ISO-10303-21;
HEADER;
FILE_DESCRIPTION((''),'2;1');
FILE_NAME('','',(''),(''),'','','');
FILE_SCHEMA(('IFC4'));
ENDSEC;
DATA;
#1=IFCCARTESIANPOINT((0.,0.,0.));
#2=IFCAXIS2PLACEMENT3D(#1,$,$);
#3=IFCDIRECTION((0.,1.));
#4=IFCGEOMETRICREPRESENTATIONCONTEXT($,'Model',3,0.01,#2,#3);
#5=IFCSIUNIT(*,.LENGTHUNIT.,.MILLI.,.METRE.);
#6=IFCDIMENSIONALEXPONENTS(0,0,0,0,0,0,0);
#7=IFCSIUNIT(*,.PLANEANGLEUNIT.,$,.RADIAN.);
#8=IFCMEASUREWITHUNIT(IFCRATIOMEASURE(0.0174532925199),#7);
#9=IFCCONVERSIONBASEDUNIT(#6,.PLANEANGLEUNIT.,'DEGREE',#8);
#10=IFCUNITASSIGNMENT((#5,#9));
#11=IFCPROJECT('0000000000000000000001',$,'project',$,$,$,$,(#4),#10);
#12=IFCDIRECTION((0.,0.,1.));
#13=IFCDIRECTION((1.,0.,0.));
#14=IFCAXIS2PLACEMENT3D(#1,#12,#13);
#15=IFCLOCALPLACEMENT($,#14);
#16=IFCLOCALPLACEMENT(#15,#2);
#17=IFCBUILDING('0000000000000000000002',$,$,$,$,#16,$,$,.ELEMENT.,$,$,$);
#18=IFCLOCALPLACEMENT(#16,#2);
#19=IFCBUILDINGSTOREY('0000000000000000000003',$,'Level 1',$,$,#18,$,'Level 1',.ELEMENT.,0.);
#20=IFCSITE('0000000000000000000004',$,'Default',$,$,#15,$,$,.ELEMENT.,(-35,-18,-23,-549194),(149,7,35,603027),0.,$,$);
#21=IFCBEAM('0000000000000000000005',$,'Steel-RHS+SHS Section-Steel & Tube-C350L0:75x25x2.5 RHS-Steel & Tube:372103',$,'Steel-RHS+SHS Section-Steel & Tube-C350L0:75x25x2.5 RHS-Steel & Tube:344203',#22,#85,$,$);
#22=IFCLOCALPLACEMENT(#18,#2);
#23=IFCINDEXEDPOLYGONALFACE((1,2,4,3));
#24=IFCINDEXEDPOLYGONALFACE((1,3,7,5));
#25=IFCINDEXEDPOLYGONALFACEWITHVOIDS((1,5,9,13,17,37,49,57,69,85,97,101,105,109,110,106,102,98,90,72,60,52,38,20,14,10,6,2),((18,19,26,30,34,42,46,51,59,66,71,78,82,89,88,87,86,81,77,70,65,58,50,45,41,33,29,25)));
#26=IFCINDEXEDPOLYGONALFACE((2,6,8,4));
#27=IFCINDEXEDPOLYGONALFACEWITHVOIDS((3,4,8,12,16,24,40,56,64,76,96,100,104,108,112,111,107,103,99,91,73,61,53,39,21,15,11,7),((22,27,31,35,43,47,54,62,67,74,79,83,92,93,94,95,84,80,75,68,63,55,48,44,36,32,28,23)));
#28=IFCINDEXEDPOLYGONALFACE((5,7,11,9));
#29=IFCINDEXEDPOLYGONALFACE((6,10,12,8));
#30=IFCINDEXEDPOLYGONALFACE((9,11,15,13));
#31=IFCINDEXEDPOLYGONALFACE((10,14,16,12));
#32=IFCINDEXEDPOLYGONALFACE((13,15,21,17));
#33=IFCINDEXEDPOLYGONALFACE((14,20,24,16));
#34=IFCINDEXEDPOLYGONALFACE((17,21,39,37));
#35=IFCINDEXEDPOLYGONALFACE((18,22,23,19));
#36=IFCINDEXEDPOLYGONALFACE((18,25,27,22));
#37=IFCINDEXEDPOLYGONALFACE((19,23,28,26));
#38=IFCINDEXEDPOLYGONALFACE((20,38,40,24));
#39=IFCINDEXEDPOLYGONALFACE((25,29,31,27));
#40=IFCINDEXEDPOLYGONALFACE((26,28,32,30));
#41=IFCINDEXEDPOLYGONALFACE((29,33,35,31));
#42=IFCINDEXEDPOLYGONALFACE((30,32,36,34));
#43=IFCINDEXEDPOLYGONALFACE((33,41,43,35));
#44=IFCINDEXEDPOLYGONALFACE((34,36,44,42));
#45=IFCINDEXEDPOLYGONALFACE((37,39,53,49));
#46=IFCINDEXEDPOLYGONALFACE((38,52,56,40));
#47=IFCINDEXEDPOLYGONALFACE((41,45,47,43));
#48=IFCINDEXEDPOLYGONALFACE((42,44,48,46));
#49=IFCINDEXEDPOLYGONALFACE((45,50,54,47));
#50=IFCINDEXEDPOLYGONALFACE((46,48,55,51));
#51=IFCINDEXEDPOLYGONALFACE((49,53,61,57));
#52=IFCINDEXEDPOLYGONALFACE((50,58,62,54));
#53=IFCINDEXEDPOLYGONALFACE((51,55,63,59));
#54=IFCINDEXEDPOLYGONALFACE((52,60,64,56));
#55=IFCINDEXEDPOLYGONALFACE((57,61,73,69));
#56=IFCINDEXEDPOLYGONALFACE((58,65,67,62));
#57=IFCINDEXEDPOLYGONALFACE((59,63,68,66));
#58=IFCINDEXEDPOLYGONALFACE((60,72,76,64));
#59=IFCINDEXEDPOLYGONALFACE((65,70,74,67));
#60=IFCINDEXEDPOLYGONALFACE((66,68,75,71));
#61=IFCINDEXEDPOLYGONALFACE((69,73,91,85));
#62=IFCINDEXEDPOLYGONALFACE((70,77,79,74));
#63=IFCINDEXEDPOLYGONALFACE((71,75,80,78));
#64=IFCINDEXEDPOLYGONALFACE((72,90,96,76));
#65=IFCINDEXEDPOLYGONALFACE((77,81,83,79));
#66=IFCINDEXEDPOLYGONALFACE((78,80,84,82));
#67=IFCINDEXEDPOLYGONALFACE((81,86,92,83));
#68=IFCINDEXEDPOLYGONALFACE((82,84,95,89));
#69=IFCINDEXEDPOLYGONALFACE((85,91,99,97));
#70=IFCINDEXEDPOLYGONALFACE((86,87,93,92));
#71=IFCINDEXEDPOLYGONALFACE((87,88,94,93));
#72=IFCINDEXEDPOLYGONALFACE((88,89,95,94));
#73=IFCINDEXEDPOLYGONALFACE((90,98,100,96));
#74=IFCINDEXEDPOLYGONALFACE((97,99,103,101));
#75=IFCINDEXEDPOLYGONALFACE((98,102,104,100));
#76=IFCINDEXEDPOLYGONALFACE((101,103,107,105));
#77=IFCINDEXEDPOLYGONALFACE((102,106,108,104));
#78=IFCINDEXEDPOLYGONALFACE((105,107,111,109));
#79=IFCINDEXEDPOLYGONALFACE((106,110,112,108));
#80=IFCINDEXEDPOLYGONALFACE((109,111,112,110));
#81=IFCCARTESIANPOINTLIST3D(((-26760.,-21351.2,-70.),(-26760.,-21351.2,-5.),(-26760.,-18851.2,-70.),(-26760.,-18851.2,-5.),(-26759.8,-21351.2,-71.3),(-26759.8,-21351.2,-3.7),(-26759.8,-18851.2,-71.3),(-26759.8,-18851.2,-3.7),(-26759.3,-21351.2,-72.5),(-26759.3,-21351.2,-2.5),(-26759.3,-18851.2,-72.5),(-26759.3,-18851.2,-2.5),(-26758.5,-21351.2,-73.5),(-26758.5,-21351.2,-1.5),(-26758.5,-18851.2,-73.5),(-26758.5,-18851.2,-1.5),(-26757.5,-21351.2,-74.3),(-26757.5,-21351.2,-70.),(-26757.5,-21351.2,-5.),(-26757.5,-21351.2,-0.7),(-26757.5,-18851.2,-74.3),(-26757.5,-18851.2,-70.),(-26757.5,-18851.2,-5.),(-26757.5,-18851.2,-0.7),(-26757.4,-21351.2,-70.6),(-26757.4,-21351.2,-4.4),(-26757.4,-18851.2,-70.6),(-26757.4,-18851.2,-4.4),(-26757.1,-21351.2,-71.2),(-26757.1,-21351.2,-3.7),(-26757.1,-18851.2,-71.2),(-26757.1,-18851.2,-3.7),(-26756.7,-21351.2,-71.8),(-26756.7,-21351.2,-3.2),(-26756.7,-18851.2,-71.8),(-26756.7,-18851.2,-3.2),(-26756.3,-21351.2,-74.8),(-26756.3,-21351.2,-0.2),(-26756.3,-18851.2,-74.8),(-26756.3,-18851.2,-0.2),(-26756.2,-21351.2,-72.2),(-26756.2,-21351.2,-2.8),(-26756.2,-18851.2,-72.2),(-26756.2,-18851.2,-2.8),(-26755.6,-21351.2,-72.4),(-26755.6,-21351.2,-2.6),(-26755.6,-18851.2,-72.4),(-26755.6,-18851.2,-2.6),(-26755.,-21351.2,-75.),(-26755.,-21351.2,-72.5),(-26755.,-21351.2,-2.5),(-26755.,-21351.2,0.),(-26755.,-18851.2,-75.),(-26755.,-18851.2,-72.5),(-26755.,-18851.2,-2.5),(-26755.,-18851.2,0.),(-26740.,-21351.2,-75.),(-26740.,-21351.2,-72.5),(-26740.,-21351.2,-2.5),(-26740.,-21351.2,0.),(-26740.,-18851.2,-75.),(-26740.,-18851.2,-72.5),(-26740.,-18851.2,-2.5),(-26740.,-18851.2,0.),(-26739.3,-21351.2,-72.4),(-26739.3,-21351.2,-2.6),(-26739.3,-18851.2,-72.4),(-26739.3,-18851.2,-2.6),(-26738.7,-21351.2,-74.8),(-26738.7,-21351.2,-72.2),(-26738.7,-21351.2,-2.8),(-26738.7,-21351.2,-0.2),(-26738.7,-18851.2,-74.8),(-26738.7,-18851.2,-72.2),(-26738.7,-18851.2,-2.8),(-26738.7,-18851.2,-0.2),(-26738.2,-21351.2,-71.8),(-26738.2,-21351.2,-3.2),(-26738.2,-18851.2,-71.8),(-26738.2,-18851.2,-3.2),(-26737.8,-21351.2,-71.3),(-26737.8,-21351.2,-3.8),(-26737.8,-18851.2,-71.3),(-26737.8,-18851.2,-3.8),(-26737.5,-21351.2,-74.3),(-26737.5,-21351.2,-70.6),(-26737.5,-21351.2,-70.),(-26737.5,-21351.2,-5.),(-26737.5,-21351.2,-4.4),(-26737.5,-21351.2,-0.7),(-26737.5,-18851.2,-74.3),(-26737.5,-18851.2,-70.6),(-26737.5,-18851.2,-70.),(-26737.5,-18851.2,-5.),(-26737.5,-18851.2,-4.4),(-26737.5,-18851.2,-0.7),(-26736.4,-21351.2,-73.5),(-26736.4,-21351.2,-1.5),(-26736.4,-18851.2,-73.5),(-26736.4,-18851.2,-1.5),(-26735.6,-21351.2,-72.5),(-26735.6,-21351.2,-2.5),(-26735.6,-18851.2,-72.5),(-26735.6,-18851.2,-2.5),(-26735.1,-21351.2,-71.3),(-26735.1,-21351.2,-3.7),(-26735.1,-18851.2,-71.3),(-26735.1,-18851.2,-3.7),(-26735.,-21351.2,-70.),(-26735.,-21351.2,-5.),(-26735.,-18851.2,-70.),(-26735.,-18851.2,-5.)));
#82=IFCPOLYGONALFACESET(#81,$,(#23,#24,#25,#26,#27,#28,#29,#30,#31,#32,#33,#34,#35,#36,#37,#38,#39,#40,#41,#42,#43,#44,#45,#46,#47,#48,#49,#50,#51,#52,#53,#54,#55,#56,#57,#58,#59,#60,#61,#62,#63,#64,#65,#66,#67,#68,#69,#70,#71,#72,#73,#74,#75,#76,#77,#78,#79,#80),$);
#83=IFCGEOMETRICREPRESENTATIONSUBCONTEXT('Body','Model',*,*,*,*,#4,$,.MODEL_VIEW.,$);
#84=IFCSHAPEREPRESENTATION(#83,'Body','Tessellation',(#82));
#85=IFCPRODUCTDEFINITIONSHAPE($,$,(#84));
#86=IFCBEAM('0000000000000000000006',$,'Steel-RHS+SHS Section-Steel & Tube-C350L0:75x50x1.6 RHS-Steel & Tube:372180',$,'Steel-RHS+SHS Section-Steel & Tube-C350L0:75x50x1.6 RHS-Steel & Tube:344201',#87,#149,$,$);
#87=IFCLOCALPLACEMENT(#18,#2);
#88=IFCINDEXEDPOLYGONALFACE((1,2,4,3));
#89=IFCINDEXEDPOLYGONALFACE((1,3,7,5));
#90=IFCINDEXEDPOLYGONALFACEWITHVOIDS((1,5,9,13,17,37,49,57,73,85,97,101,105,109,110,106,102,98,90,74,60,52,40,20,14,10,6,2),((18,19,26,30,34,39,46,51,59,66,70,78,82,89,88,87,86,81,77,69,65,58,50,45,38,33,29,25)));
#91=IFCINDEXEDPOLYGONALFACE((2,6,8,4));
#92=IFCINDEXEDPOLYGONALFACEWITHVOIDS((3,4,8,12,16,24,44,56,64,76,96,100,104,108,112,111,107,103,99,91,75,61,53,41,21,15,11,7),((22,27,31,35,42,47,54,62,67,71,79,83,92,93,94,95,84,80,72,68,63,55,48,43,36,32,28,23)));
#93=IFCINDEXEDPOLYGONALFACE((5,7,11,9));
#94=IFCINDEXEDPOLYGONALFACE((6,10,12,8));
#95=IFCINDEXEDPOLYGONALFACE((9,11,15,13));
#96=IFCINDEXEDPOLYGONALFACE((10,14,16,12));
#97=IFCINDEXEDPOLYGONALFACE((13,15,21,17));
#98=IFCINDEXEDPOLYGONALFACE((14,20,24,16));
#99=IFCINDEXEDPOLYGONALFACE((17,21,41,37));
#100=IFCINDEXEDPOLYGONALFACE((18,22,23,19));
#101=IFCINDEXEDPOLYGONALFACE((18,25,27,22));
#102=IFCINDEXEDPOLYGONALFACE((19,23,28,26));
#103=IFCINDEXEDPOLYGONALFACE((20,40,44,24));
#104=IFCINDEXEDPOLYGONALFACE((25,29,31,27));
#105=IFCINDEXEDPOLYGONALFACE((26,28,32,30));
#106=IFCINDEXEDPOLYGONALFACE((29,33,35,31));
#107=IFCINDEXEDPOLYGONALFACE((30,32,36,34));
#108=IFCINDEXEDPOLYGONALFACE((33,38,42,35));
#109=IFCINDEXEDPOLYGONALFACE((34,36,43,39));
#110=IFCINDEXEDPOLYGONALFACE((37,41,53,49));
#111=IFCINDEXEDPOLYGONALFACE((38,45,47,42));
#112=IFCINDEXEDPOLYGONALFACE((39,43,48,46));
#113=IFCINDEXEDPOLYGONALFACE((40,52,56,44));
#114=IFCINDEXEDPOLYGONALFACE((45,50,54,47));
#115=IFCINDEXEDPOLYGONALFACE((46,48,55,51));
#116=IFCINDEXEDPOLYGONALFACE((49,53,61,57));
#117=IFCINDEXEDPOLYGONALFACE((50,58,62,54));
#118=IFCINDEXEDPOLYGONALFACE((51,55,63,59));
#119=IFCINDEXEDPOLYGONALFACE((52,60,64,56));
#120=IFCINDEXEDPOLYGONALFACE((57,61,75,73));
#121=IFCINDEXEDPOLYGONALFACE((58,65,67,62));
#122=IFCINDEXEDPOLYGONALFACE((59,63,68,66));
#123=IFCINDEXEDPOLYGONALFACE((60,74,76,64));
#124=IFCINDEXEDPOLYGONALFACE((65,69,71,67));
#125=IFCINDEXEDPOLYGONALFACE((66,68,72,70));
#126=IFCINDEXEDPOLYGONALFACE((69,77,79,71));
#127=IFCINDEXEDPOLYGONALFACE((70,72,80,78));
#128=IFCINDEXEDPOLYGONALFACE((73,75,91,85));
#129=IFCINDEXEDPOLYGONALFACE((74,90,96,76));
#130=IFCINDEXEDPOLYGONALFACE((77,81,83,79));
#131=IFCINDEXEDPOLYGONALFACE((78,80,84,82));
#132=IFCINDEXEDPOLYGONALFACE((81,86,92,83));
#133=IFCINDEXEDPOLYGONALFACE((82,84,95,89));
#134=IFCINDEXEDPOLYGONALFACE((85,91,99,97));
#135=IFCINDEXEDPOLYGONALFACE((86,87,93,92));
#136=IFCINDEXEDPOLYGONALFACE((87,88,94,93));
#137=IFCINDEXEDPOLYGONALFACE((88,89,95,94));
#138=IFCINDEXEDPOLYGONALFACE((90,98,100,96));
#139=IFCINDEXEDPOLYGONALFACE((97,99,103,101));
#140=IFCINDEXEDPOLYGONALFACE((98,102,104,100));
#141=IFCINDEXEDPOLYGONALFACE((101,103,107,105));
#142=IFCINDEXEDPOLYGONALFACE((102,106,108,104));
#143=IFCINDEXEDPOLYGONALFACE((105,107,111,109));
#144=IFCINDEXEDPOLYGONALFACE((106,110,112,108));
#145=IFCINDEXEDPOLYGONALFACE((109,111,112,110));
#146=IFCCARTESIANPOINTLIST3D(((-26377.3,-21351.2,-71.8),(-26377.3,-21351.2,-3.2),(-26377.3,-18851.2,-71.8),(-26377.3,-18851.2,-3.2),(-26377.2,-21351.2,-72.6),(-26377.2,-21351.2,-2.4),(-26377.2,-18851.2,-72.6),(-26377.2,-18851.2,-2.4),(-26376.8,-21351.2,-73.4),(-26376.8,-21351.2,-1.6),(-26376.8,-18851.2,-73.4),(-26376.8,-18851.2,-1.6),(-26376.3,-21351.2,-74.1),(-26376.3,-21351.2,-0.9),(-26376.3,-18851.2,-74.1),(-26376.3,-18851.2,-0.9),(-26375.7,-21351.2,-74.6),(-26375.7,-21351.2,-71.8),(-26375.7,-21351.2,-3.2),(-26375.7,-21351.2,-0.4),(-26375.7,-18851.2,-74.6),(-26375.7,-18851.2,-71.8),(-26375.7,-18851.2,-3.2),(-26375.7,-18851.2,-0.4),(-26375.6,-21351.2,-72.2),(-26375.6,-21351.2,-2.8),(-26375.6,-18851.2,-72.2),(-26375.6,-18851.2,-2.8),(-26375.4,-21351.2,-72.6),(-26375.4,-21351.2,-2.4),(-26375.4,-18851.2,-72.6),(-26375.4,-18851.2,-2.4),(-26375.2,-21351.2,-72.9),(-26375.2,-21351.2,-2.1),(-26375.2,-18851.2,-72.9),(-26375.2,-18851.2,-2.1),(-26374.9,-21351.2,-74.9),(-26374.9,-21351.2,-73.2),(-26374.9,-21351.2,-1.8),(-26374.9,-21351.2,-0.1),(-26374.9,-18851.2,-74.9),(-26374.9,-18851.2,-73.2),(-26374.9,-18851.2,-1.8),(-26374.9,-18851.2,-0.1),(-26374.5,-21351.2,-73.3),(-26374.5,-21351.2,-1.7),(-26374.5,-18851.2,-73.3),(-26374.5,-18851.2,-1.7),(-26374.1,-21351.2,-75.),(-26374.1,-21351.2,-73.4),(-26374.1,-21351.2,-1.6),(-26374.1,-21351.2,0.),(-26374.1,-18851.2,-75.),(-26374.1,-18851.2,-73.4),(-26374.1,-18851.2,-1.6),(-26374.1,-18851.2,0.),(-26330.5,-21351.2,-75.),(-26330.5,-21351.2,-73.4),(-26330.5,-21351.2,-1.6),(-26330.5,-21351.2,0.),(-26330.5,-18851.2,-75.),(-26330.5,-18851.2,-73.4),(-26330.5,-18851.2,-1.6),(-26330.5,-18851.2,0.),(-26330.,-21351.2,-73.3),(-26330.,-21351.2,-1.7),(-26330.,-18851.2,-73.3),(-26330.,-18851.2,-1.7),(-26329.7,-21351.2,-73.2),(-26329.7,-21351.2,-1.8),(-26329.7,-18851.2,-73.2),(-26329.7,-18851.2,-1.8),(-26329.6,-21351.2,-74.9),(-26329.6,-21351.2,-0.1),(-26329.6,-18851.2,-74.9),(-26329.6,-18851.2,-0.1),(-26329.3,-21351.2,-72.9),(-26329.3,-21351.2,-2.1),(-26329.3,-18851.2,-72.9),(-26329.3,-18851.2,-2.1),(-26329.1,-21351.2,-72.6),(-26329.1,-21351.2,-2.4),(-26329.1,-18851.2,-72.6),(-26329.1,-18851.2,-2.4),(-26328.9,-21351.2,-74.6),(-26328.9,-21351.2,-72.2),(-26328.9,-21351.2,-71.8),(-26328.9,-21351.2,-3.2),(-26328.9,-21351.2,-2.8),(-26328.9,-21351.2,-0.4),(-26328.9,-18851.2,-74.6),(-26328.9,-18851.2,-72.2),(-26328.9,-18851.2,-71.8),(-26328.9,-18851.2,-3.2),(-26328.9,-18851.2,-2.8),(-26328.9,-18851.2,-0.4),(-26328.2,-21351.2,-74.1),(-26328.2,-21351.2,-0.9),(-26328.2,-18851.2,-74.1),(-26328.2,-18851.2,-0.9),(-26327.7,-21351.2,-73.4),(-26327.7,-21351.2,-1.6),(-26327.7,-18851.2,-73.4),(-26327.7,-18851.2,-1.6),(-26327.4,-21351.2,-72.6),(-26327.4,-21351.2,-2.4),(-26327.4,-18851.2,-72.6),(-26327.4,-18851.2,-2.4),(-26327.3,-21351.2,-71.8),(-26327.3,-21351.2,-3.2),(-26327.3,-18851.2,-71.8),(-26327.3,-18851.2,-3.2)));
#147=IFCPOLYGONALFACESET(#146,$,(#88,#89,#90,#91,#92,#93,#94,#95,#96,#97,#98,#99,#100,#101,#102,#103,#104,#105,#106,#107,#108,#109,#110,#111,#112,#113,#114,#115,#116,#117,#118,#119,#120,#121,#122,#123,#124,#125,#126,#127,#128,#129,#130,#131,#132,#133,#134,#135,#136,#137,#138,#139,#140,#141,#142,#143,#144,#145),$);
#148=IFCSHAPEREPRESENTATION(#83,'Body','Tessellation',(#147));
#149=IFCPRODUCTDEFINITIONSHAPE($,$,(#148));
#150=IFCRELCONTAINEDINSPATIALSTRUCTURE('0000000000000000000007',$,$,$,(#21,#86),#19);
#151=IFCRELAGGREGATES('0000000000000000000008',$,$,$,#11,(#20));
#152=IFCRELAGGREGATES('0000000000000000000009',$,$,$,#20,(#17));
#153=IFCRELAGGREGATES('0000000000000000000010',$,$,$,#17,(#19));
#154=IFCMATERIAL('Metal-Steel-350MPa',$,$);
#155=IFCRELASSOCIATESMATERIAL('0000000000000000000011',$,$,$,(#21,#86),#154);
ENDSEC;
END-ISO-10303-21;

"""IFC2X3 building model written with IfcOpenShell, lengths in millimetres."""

from ifc_helpers import new_model, entity, si_unit, converted_unit, direction, frame, frame_2d, origin, origin_with_axes, place, context, subcontext, project, spatial, polyline, circle_curve, parameter, trimmed, segment, composite_curve, outline, extrude, material, element, save


model = new_model("IFC2X3")

# Units and contexts
model_context = context("Model", 3, precision=0.01, world=origin(), true_north=direction((0.0, 1.0)))
body_context = subcontext(model_context, "Body", "Model", "MODEL_VIEW")
ifc_project = project(units=[si_unit("LENGTHUNIT", "METRE", prefix="MILLI"), converted_unit("PLANEANGLEUNIT", "DEGREE", entity("IfcRatioMeasure", 0.0174532925199), si_unit("PLANEANGLEUNIT", "RADIAN"), dimensions=[0, 0, 0, 0, 0, 0, 0])], contexts=[model_context])

# Site, building, storey
site_placement = place(None, origin_with_axes())
site = spatial("IfcSite", under=ifc_project, at=site_placement, Name="Default", CompositionType="ELEMENT", RefLatitude=(-35, -18, -23, -549194), RefLongitude=(149, 7, 35, 603027), RefElevation=0.0)
building_placement = place(site_placement, origin())
building = spatial("IfcBuilding", under=site, at=building_placement, CompositionType="ELEMENT")
storey_placement = place(building_placement, origin())
storey = spatial("IfcBuildingStorey", under=building, at=storey_placement, Name="Level 1", LongName="Level 1", CompositionType="ELEMENT", Elevation=0.0)

# Beams
ifc_material = material(Name="Metal-Steel-350MPa")
beam_1_placement = place(storey_placement, frame((-26747.5, -18851.2, 0.0), z_axis=(0.0, 0.0, 1.0), x_axis=(0.0, -1.0, 0.0)))
element("IfcBeam", 1, at=beam_1_placement, inside=storey, material=ifc_material, Name="Steel-RHS+SHS Section-Steel & Tube-C350L0:75x25x2.5 RHS-Steel & Tube:372103", ObjectType="Steel-RHS+SHS Section-Steel & Tube-C350L0:75x25x2.5 RHS-Steel & Tube:344203", context=body_context, shape_type="SweptSolid", body=[
    extrude(outline(composite_curve([segment(trimmed(circle_curve(frame_2d((-7.5, -32.5), x_axis=(1.0, 0.0)), 5.0), [parameter(180.0)], [parameter(270.0)], True, "PARAMETER"), True, "CONTINUOUS"), segment(polyline([(-7.5, -37.5), (7.5, -37.5)]), True, "CONTINUOUS"), segment(trimmed(circle_curve(frame_2d((7.5, -32.5), x_axis=(1.0, 0.0)), 5.0), [parameter(270.0)], [parameter(0.0)], True, "PARAMETER"), True, "CONTINUOUS"), segment(polyline([(12.5, -32.5), (12.5, 32.5)]), True, "CONTINUOUS"), segment(trimmed(circle_curve(frame_2d((7.5, 32.5), x_axis=(1.0, 0.0)), 5.0), [parameter(0.0)], [parameter(90.0)], True, "PARAMETER"), True, "CONTINUOUS"), segment(polyline([(7.5, 37.5), (-7.5, 37.5)]), True, "CONTINUOUS"), segment(trimmed(circle_curve(frame_2d((-7.5, 32.5), x_axis=(1.0, 0.0)), 5.0), [parameter(90.0)], [parameter(180.0)], True, "PARAMETER"), True, "CONTINUOUS"), segment(polyline([(-12.5, 32.5), (-12.5, -32.5)]), True, "CONTINUOUS")], self_intersect=False), holes=[composite_curve([segment(polyline([(7.5, -35.0), (-7.5, -35.0)]), True, "CONTINUOUS"), segment(trimmed(circle_curve(frame_2d((-7.5, -32.5), x_axis=(1.0, 0.0)), 2.5), [parameter(180.0)], [parameter(270.0)], True, "PARAMETER"), False, "CONTINUOUS"), segment(polyline([(-10.0, -32.5), (-10.0, 32.5)]), True, "CONTINUOUS"), segment(trimmed(circle_curve(frame_2d((-7.5, 32.5), x_axis=(1.0, 0.0)), 2.5), [parameter(90.0)], [parameter(180.0)], True, "PARAMETER"), False, "CONTINUOUS"), segment(polyline([(-7.5, 35.0), (7.5, 35.0)]), True, "CONTINUOUS"), segment(trimmed(circle_curve(frame_2d((7.5, 32.5), x_axis=(1.0, 0.0)), 2.5), [parameter(360.0)], [parameter(90.0)], True, "PARAMETER"), False, "CONTINUOUS"), segment(polyline([(10.0, 32.5), (10.0, -32.5)]), True, "CONTINUOUS"), segment(trimmed(circle_curve(frame_2d((7.5, -32.5), x_axis=(1.0, 0.0)), 2.5), [parameter(270.0)], [parameter(0.0)], True, "PARAMETER"), False, "CONTINUOUS")], self_intersect=False)]), frame((0.0, 0.0, -37.5), z_axis=(1.0, 0.0, 0.0), x_axis=(0.0, -1.0, 0.0)), (0.0, 0.0, 1.0), 2500.0),
])
beam_2_placement = place(storey_placement, frame((-26352.3, -18851.2, 0.0), z_axis=(0.0, 0.0, 1.0), x_axis=(0.0, -1.0, 0.0)))
element("IfcBeam", 2, at=beam_2_placement, inside=storey, material=ifc_material, Name="Steel-RHS+SHS Section-Steel & Tube-C350L0:75x50x1.6 RHS-Steel & Tube:372180", ObjectType="Steel-RHS+SHS Section-Steel & Tube-C350L0:75x50x1.6 RHS-Steel & Tube:344201", context=body_context, shape_type="SweptSolid", body=[
    extrude(outline(composite_curve([segment(trimmed(circle_curve(frame_2d((-21.8, -34.3), x_axis=(1.0, 0.0)), 3.2), [parameter(180.0)], [parameter(270.0)], True, "PARAMETER"), True, "CONTINUOUS"), segment(polyline([(-21.8, -37.5), (21.8, -37.5)]), True, "CONTINUOUS"), segment(trimmed(circle_curve(frame_2d((21.8, -34.3), x_axis=(1.0, 0.0)), 3.2), [parameter(270.0)], [parameter(0.0)], True, "PARAMETER"), True, "CONTINUOUS"), segment(polyline([(25.0, -34.3), (25.0, 34.3)]), True, "CONTINUOUS"), segment(trimmed(circle_curve(frame_2d((21.8, 34.3), x_axis=(1.0, 0.0)), 3.2), [parameter(0.0)], [parameter(90.0)], True, "PARAMETER"), True, "CONTINUOUS"), segment(polyline([(21.8, 37.5), (-21.8, 37.5)]), True, "CONTINUOUS"), segment(trimmed(circle_curve(frame_2d((-21.8, 34.3), x_axis=(1.0, 0.0)), 3.2), [parameter(90.0)], [parameter(180.0)], True, "PARAMETER"), True, "CONTINUOUS"), segment(polyline([(-25.0, 34.3), (-25.0, -34.3)]), True, "CONTINUOUS")], self_intersect=False), holes=[composite_curve([segment(polyline([(21.8, -35.9), (-21.8, -35.9)]), True, "CONTINUOUS"), segment(trimmed(circle_curve(frame_2d((-21.8, -34.3), x_axis=(1.0, 0.0)), 1.6), [parameter(180.0)], [parameter(270.0)], True, "PARAMETER"), False, "CONTINUOUS"), segment(polyline([(-23.4, -34.3), (-23.4, 34.3)]), True, "CONTINUOUS"), segment(trimmed(circle_curve(frame_2d((-21.8, 34.3), x_axis=(1.0, 0.0)), 1.6), [parameter(90.0)], [parameter(180.0)], True, "PARAMETER"), False, "CONTINUOUS"), segment(polyline([(-21.8, 35.9), (21.8, 35.9)]), True, "CONTINUOUS"), segment(trimmed(circle_curve(frame_2d((21.8, 34.3), x_axis=(1.0, 0.0)), 1.6), [parameter(360.0)], [parameter(90.0)], True, "PARAMETER"), False, "CONTINUOUS"), segment(polyline([(23.4, 34.3), (23.4, -34.3)]), True, "CONTINUOUS"), segment(trimmed(circle_curve(frame_2d((21.8, -34.3), x_axis=(1.0, 0.0)), 1.6), [parameter(270.0)], [parameter(0.0)], True, "PARAMETER"), False, "CONTINUOUS")], self_intersect=False)]), frame((0.0, 0.0, -37.5), z_axis=(1.0, 0.0, 0.0), x_axis=(0.0, -1.0, 0.0)), (0.0, 0.0, 1.0), 2500.0),
])

save(model, "model.ifc")
